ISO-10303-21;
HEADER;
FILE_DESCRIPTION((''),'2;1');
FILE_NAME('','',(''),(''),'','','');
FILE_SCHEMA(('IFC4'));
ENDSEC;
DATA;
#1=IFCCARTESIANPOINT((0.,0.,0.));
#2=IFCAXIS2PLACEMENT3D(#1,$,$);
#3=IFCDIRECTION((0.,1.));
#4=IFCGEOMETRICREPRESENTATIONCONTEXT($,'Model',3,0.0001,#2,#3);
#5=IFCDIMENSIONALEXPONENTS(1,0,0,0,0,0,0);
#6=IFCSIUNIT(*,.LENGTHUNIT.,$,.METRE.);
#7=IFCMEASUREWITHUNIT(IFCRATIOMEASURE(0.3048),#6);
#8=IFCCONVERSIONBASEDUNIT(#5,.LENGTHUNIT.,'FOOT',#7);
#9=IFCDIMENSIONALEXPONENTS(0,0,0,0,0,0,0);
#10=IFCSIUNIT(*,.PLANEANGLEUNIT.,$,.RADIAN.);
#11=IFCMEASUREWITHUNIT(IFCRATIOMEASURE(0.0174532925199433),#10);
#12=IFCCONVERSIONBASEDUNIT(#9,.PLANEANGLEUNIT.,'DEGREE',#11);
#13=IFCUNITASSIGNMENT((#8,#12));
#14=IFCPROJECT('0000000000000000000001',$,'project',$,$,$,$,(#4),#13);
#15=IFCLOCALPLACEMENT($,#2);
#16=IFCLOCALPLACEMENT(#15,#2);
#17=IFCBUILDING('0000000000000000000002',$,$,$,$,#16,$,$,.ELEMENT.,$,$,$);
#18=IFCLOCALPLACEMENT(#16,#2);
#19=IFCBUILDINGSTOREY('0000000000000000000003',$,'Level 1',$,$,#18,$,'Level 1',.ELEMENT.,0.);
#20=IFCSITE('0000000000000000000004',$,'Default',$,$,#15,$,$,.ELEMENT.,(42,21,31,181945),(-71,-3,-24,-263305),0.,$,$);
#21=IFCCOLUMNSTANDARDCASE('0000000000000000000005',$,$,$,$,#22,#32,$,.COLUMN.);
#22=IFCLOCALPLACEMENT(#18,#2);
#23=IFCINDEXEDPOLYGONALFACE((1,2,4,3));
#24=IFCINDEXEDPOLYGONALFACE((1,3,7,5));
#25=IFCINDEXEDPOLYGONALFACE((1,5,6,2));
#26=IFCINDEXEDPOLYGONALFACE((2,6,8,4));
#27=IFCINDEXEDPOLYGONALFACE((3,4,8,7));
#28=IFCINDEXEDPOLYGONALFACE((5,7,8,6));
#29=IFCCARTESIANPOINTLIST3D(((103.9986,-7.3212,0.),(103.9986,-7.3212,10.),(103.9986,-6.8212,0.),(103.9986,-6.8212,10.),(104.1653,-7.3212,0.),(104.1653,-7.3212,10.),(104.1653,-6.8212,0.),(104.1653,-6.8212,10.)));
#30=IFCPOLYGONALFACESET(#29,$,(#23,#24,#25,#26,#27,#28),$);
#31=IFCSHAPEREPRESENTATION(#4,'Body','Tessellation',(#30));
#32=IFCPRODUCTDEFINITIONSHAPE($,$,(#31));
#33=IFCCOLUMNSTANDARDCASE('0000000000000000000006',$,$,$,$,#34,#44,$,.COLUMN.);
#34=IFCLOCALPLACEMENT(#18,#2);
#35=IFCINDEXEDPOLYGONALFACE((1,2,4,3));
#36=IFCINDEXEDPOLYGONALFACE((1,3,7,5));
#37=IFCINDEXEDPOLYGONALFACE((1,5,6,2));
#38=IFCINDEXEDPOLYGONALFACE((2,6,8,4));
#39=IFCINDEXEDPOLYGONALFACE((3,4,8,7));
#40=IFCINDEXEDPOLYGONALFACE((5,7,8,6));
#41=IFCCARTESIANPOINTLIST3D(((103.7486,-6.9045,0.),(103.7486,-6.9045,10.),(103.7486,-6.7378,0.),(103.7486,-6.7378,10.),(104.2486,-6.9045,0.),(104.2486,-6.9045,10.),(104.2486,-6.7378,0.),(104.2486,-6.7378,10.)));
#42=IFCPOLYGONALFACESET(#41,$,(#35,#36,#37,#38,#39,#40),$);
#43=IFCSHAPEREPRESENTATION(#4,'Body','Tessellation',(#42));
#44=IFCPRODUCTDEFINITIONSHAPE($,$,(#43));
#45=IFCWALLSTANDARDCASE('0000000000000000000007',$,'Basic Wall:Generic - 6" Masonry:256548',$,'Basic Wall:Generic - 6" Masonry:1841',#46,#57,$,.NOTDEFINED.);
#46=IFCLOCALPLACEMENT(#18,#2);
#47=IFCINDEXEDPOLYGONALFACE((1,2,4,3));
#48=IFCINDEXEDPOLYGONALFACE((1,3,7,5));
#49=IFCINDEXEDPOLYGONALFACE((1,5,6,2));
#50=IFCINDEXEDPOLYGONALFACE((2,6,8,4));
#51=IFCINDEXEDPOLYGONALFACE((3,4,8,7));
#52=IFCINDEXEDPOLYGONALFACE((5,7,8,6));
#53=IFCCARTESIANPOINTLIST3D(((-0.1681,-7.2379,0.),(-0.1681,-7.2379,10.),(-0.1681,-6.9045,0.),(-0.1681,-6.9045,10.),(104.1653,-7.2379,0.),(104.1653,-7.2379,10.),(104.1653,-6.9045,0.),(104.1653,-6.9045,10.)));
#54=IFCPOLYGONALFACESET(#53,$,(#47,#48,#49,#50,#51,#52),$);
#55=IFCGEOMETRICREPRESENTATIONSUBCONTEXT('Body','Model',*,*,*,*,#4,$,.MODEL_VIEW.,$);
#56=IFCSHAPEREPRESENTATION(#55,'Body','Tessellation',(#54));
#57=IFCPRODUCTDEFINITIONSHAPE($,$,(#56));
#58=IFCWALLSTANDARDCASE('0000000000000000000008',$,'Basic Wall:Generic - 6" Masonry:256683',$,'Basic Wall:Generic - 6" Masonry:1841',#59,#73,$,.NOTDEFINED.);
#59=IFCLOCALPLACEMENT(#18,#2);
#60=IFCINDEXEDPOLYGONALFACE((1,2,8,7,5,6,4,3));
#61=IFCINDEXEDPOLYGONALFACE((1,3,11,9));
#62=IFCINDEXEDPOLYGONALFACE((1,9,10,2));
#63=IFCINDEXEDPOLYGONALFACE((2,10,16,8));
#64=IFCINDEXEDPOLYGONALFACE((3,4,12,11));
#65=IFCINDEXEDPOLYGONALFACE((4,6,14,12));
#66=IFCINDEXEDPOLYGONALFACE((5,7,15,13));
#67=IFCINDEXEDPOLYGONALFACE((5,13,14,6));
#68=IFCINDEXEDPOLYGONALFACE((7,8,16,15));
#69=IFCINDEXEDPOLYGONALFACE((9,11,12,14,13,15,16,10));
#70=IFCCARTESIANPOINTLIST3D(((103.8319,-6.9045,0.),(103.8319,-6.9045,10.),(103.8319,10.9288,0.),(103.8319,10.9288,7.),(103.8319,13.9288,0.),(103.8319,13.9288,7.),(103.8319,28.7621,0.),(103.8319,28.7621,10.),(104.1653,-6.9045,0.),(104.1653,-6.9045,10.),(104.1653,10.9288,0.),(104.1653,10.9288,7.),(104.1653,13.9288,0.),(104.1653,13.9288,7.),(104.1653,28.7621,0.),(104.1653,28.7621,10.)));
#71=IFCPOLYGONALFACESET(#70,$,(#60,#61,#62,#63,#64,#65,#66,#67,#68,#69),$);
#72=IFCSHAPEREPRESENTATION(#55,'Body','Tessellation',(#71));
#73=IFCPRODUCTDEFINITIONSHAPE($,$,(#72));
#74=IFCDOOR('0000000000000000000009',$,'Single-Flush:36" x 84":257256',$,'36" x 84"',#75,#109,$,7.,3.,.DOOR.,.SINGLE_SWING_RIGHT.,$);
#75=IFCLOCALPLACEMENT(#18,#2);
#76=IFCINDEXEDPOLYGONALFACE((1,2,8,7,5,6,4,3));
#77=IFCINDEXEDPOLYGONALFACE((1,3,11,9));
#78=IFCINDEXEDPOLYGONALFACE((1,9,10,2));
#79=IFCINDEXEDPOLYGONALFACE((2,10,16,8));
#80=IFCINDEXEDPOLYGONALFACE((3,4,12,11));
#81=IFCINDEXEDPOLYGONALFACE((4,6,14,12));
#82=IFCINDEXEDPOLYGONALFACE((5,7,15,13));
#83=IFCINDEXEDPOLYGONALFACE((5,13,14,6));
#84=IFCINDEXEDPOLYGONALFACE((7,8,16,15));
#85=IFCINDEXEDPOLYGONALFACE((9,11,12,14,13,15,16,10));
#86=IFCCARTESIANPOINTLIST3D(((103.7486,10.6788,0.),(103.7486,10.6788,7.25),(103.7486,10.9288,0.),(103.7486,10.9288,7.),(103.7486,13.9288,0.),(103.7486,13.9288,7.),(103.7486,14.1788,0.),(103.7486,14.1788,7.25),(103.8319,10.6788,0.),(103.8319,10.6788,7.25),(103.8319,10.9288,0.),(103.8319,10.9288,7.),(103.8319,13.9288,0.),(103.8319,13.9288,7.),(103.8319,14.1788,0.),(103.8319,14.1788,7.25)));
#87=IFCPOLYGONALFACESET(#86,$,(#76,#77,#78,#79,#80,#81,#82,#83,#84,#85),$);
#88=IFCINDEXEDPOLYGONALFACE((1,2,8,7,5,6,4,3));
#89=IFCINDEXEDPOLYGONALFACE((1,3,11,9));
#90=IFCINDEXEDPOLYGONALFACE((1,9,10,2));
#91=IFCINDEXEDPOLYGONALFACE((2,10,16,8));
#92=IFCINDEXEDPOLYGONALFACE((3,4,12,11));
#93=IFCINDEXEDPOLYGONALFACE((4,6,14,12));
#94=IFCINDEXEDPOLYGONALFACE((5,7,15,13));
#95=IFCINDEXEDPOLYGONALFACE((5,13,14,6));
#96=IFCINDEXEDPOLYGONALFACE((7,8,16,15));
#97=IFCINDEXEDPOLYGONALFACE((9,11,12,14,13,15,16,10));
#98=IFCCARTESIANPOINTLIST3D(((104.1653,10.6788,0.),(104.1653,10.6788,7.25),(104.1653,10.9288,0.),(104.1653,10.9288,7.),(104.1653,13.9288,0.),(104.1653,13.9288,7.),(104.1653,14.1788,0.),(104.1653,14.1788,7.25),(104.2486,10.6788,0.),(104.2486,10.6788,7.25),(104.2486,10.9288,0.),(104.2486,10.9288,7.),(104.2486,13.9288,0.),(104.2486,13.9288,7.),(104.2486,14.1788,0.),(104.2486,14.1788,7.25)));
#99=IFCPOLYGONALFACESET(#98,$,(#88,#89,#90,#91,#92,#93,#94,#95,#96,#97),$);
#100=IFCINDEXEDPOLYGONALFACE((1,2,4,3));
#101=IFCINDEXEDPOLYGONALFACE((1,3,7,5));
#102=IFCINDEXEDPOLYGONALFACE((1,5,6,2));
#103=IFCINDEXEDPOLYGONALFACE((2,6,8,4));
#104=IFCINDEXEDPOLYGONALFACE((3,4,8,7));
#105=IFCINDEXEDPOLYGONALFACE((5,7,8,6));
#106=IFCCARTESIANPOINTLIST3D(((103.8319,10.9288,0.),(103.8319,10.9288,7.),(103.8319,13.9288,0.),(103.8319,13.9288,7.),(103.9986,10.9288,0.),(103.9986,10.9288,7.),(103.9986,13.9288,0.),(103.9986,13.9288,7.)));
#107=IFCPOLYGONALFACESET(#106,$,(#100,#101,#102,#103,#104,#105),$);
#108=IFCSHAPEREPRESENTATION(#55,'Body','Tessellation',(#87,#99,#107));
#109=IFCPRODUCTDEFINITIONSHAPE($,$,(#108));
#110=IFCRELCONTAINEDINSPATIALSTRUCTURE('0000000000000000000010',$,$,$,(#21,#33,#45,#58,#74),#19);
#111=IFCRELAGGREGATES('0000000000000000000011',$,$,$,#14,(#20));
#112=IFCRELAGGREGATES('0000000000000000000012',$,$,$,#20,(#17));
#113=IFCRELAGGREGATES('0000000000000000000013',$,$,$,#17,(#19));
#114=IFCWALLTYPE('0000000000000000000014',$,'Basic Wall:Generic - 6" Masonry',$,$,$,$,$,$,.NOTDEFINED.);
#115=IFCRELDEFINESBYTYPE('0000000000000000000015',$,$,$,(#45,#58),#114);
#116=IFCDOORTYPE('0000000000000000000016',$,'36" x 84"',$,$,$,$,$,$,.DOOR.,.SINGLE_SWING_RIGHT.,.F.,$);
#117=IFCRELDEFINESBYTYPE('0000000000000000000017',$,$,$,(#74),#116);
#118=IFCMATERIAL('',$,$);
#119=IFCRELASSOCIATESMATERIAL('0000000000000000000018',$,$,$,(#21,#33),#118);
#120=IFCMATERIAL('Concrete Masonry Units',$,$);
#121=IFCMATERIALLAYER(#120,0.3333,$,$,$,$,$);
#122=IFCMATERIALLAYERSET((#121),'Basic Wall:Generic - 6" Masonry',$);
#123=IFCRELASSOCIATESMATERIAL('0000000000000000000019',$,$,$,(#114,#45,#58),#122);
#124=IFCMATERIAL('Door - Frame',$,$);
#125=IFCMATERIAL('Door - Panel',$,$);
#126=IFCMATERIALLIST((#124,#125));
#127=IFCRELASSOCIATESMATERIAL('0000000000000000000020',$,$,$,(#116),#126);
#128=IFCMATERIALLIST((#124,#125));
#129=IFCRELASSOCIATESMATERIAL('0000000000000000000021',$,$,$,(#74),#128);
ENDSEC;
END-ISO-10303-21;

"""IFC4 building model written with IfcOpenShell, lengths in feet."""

from ifc_helpers import new_model, entity, si_unit, converted_unit, direction, frame, frame_2d, origin, place, context, subcontext, project, spatial, polyline, rectangle, outline, extrude, source, transform, mapped, material, material_list, layer, layer_set, layer_usage, type_object, type_shapes, element, fill, save


model = new_model("IFC4")

# Units and contexts
model_context = context("Model", 3, precision=0.0001, world=origin(), true_north=direction((0.0, 1.0)))
body_context = subcontext(model_context, "Body", "Model", "MODEL_VIEW")
ifc_project = project(units=[converted_unit("LENGTHUNIT", "FOOT", entity("IfcRatioMeasure", 0.3048), si_unit("LENGTHUNIT", "METRE"), dimensions=[1, 0, 0, 0, 0, 0, 0]), converted_unit("PLANEANGLEUNIT", "DEGREE", entity("IfcRatioMeasure", 0.0174532925199433), si_unit("PLANEANGLEUNIT", "RADIAN"), dimensions=[0, 0, 0, 0, 0, 0, 0])], contexts=[model_context])

# Site, building, storey
site_placement = place(None, origin())
site = spatial("IfcSite", under=ifc_project, at=site_placement, Name="Default", CompositionType="ELEMENT", RefLatitude=(42, 21, 31, 181945), RefLongitude=(-71, -3, -24, -263305), RefElevation=0.0)
building_placement = place(site_placement, origin())
building = spatial("IfcBuilding", under=site, at=building_placement, CompositionType="ELEMENT")
storey_placement = place(building_placement, origin())
storey = spatial("IfcBuildingStorey", under=building, at=storey_placement, Name="Level 1", LongName="Level 1", CompositionType="ELEMENT", Elevation=0.0)

# Columns
ifc_material_1 = material(Name="")
wall_1_placement = place(storey_placement, frame((104.1653, -7.0712, 0.0), z_axis=(0.0, 0.0, 1.0), x_axis=(-1.0, 0.0, 0.0)))
for number, where, z_axis, x_axis in (
    (1, (0.0833, 0.0, 0.0), (0.0, 0.0, 1.0), (1.0, 0.0, 0.0)),
):
    element("IfcColumnStandardCase", number, at=place(wall_1_placement, frame(where, z_axis=z_axis, x_axis=x_axis)), inside=storey, material=ifc_material_1, PredefinedType="COLUMN", context=model_context, shape_type="SweptSolid", body=[
        extrude(rectangle(XDim=0.1667, YDim=0.5), origin(), (0.0, 0.0, 1.0), 10.0),
    ])
wall_2_placement = place(storey_placement, frame((103.9986, -6.9045, 0.0), z_axis=(0.0, 0.0, 1.0), x_axis=(0.0, 1.0, 0.0)))
for number, where, z_axis, x_axis in (
    (2, (0.0833, 0.0, 0.0), (0.0, 0.0, 1.0), (1.0, 0.0, 0.0)),
):
    element("IfcColumnStandardCase", number, at=place(wall_2_placement, frame(where, z_axis=z_axis, x_axis=x_axis)), inside=storey, material=ifc_material_1, PredefinedType="COLUMN", context=model_context, shape_type="SweptSolid", body=[
        extrude(rectangle(XDim=0.1667, YDim=0.5), origin(), (0.0, 0.0, 1.0), 10.0),
    ])

# Wall
ifc_material_2 = material(Name="Concrete Masonry Units")
ifc_layer = layer(ifc_material_2, 0.3333)
ifc_layer_set = layer_set([ifc_layer], Name="Basic Wall:Generic - 6\" Masonry")
ifc_layer_usage_1 = layer_usage(ifc_layer_set, "AXIS2", "NEGATIVE", 0.1667)
wall_type = type_object("IfcWallType", Name="Basic Wall:Generic - 6\" Masonry", PredefinedType="NOTDEFINED", material=ifc_layer_set)
element("IfcWallStandardCase", 3, at=wall_1_placement, inside=storey, type_object=wall_type, material=ifc_layer_usage_1, Name="Basic Wall:Generic - 6\" Masonry:256548", ObjectType="Basic Wall:Generic - 6\" Masonry:1841", PredefinedType="NOTDEFINED", context=body_context, shape_type="SweptSolid", body=[
    extrude(rectangle(XDim=104.3333, YDim=0.3333, at=frame_2d((52.1667, 0.0), x_axis=(-1.0, 0.0))), origin(), (0.0, 0.0, 1.0), 10.0),
])

# Wall, opening, door
ifc_layer_usage_2 = layer_usage(ifc_layer_set, "AXIS2", "NEGATIVE", 0.1667)
wall_2 = element("IfcWallStandardCase", 4, at=wall_2_placement, inside=storey, type_object=wall_type, material=ifc_layer_usage_2, Name="Basic Wall:Generic - 6\" Masonry:256683", ObjectType="Basic Wall:Generic - 6\" Masonry:1841", PredefinedType="NOTDEFINED", context=body_context, shape_type="SweptSolid", body=[
    extrude(rectangle(XDim=35.6667, YDim=0.3333, at=frame_2d((17.8333, 0.0), x_axis=(-1.0, 0.0))), origin(), (0.0, 0.0, 1.0), 10.0),
])
opening_1_placement = place(wall_2_placement, frame((17.8333, -0.1667, 0.0)))
opening_1 = element("IfcOpeningElement", 5, at=opening_1_placement, cuts=wall_2, ObjectType="Opening", PredefinedType="OPENING", context=body_context, shape_type="SweptSolid", body=[
    extrude(rectangle(XDim=3.0, YDim=7.0, at=frame_2d((3.5, 1.5), x_axis=(0.0, 1.0))), frame((0.0, 0.0, 0.0), z_axis=(0.0, 1.0, 0.0), x_axis=(0.0, 0.0, 1.0)), (0.0, 0.0, 1.0), 0.3333),
])
ifc_material_3 = material(Name="Door - Frame")
ifc_material_4 = material(Name="Door - Panel")
ifc_material_list_1 = material_list([ifc_material_3, ifc_material_4])
ifc_material_list_2 = material_list([ifc_material_3, ifc_material_4])
door_type = type_object("IfcDoorType", Name="36\" x 84\"", OperationType="SINGLE_SWING_RIGHT", ParameterTakesPrecedence=False, PredefinedType="DOOR", material=ifc_material_list_2)
shared_shape_1 = source(origin(), body_context, "Body", "SweptSolid", [
    extrude(outline(polyline([(-1.75, -3.6875), (1.75, -3.6875), (1.75, 3.5625), (1.5, 3.5625), (1.5, -3.4375), (-1.5, -3.4375), (-1.5, 3.5625), (-1.75, 3.5625), (-1.75, -3.6875)])), frame((1.5, 0.3333, 3.5625), z_axis=(0.0, 1.0, 0.0), x_axis=(1.0, 0.0, 0.0)), (0.0, 0.0, 1.0), 0.0833),
    extrude(outline(polyline([(-3.6875, -1.75), (3.5625, -1.75), (3.5625, -1.5), (-3.4375, -1.5), (-3.4375, 1.5), (3.5625, 1.5), (3.5625, 1.75), (-3.6875, 1.75), (-3.6875, -1.75)])), frame((1.5, -0.0833, 3.5625), z_axis=(0.0, 1.0, 0.0), x_axis=(0.0, 0.0, -1.0)), (0.0, 0.0, 1.0), 0.0833),
    extrude(rectangle(XDim=0.1667, YDim=3.0, at=frame_2d((0.0, 0.0), x_axis=(1.0, 0.0))), frame((1.5, 0.25, 0.0), z_axis=(0.0, 0.0, 1.0), x_axis=(0.0, 1.0, 0.0)), (0.0, 0.0, 1.0), 7.0),
])
type_shapes(door_type, [shared_shape_1])
door_1_placement = place(opening_1_placement, origin())
door_1 = element("IfcDoor", 6, at=door_1_placement, inside=storey, type_object=door_type, material=ifc_material_list_1, Name="Single-Flush:36\" x 84\":257256", ObjectType="36\" x 84\"", OperationType="SINGLE_SWING_RIGHT", OverallHeight=7.0, OverallWidth=3.0, PredefinedType="DOOR", context=body_context, shape_type="MappedRepresentation", body=[
    mapped(shared_shape_1, transform((0.0, 0.0, 0.0), scale=1.0)),
])
fill(opening_1, door_1)

save(model, "model.ifc")
